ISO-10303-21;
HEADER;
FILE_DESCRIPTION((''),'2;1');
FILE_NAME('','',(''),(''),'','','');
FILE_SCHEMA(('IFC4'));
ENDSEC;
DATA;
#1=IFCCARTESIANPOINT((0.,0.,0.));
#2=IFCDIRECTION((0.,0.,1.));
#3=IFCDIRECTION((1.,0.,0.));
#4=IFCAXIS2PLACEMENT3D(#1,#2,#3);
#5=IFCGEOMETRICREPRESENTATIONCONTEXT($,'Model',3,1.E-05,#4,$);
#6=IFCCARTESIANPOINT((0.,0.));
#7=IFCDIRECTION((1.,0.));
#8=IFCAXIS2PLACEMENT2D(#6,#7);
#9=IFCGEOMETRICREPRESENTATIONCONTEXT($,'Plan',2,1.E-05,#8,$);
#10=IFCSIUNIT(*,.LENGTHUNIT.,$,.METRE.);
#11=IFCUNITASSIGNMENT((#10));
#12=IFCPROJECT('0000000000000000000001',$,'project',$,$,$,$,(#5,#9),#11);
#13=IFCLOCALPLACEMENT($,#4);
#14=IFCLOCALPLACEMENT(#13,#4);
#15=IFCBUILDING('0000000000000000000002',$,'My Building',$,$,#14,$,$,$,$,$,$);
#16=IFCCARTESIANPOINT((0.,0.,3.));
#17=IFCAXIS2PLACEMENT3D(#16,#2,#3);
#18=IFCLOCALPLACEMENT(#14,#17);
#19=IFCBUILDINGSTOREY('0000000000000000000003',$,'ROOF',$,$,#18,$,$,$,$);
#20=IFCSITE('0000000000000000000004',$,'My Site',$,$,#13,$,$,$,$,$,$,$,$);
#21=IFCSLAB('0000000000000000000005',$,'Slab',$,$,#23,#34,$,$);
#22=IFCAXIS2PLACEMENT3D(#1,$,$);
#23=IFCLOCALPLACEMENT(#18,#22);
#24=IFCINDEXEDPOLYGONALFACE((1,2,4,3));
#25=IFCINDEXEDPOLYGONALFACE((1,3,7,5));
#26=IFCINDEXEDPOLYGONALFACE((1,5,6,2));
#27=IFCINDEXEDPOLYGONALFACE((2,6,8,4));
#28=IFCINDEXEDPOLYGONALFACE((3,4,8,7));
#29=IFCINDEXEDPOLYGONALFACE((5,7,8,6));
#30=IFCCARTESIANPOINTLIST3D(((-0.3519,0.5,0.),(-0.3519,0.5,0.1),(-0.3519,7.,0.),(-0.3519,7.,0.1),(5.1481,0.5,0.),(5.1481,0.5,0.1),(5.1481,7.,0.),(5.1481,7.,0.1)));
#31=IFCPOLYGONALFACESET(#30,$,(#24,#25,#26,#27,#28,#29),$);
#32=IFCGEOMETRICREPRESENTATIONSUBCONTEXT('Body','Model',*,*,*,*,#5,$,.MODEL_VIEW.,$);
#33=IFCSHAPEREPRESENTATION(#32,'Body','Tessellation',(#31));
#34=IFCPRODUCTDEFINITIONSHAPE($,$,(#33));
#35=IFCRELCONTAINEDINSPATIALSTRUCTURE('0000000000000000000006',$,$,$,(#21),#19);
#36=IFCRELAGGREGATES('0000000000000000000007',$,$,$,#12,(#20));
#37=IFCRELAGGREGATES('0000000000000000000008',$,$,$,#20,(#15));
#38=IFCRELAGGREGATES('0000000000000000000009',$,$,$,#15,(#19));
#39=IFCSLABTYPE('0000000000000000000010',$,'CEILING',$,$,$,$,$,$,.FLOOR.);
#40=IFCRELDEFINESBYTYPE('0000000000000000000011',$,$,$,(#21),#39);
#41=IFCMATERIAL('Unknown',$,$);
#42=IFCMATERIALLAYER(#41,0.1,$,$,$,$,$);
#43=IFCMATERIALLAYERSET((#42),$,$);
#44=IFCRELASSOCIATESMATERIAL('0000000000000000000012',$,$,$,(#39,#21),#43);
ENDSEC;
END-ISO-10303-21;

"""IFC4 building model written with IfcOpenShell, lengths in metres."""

from ifc_helpers import new_model, si_unit, frame, origin_with_axes, origin_2d_with_axis, place, context, subcontext, project, spatial, indexed_curve, outline, extrude, material, layer, layer_set, layer_usage, type_object, element, save


model = new_model("IFC4")

# Units and contexts
model_context = context("Model", 3, precision=1e-05, world=origin_with_axes())
plan_context = context("Plan", 2, precision=1e-05, world=origin_2d_with_axis())
body_context = subcontext(model_context, "Body", "Model", "MODEL_VIEW")
ifc_project = project(units=[si_unit("LENGTHUNIT", "METRE")], contexts=[model_context, plan_context])

# Site, building, storey
site_placement = place(None, origin_with_axes())
site = spatial("IfcSite", under=ifc_project, at=site_placement, Name="My Site")
building_placement = place(site_placement, origin_with_axes())
building = spatial("IfcBuilding", under=site, at=building_placement, Name="My Building")
storey_placement = place(building_placement, frame((0.0, 0.0, 3.0), z_axis=(0.0, 0.0, 1.0), x_axis=(1.0, 0.0, 0.0)))
storey = spatial("IfcBuildingStorey", under=building, at=storey_placement, Name="ROOF")

# Slab
ifc_material = material(Name="Unknown")
ifc_layer = layer(ifc_material, 0.1)
ifc_layer_set = layer_set([ifc_layer])
ifc_layer_usage = layer_usage(ifc_layer_set, "AXIS3", "POSITIVE", -0.1)
slab_type = type_object("IfcSlabType", Name="CEILING", PredefinedType="FLOOR", material=ifc_layer_set)
slab_placement = place(storey_placement, frame((-0.3519, 7.0, 0.1), z_axis=(0.0, 0.0, 1.0), x_axis=(1.0, 0.0, 0.0)))
element("IfcSlab", 1, at=slab_placement, inside=storey, type_object=slab_type, material=ifc_layer_usage, Name="Slab", context=body_context, shape_type="SweptSolid", body=[
    extrude(outline(indexed_curve([(0.0, 0.0), (5.5, 0.0), (5.5, -6.5), (0.0, -6.5), (0.0, 0.0)])), frame((0.0, 0.0, -0.1), z_axis=(0.0, 0.0, 1.0), x_axis=(1.0, 0.0, 0.0)), (0.0, 0.0, 1.0), 0.1),
])

save(model, "model.ifc")
